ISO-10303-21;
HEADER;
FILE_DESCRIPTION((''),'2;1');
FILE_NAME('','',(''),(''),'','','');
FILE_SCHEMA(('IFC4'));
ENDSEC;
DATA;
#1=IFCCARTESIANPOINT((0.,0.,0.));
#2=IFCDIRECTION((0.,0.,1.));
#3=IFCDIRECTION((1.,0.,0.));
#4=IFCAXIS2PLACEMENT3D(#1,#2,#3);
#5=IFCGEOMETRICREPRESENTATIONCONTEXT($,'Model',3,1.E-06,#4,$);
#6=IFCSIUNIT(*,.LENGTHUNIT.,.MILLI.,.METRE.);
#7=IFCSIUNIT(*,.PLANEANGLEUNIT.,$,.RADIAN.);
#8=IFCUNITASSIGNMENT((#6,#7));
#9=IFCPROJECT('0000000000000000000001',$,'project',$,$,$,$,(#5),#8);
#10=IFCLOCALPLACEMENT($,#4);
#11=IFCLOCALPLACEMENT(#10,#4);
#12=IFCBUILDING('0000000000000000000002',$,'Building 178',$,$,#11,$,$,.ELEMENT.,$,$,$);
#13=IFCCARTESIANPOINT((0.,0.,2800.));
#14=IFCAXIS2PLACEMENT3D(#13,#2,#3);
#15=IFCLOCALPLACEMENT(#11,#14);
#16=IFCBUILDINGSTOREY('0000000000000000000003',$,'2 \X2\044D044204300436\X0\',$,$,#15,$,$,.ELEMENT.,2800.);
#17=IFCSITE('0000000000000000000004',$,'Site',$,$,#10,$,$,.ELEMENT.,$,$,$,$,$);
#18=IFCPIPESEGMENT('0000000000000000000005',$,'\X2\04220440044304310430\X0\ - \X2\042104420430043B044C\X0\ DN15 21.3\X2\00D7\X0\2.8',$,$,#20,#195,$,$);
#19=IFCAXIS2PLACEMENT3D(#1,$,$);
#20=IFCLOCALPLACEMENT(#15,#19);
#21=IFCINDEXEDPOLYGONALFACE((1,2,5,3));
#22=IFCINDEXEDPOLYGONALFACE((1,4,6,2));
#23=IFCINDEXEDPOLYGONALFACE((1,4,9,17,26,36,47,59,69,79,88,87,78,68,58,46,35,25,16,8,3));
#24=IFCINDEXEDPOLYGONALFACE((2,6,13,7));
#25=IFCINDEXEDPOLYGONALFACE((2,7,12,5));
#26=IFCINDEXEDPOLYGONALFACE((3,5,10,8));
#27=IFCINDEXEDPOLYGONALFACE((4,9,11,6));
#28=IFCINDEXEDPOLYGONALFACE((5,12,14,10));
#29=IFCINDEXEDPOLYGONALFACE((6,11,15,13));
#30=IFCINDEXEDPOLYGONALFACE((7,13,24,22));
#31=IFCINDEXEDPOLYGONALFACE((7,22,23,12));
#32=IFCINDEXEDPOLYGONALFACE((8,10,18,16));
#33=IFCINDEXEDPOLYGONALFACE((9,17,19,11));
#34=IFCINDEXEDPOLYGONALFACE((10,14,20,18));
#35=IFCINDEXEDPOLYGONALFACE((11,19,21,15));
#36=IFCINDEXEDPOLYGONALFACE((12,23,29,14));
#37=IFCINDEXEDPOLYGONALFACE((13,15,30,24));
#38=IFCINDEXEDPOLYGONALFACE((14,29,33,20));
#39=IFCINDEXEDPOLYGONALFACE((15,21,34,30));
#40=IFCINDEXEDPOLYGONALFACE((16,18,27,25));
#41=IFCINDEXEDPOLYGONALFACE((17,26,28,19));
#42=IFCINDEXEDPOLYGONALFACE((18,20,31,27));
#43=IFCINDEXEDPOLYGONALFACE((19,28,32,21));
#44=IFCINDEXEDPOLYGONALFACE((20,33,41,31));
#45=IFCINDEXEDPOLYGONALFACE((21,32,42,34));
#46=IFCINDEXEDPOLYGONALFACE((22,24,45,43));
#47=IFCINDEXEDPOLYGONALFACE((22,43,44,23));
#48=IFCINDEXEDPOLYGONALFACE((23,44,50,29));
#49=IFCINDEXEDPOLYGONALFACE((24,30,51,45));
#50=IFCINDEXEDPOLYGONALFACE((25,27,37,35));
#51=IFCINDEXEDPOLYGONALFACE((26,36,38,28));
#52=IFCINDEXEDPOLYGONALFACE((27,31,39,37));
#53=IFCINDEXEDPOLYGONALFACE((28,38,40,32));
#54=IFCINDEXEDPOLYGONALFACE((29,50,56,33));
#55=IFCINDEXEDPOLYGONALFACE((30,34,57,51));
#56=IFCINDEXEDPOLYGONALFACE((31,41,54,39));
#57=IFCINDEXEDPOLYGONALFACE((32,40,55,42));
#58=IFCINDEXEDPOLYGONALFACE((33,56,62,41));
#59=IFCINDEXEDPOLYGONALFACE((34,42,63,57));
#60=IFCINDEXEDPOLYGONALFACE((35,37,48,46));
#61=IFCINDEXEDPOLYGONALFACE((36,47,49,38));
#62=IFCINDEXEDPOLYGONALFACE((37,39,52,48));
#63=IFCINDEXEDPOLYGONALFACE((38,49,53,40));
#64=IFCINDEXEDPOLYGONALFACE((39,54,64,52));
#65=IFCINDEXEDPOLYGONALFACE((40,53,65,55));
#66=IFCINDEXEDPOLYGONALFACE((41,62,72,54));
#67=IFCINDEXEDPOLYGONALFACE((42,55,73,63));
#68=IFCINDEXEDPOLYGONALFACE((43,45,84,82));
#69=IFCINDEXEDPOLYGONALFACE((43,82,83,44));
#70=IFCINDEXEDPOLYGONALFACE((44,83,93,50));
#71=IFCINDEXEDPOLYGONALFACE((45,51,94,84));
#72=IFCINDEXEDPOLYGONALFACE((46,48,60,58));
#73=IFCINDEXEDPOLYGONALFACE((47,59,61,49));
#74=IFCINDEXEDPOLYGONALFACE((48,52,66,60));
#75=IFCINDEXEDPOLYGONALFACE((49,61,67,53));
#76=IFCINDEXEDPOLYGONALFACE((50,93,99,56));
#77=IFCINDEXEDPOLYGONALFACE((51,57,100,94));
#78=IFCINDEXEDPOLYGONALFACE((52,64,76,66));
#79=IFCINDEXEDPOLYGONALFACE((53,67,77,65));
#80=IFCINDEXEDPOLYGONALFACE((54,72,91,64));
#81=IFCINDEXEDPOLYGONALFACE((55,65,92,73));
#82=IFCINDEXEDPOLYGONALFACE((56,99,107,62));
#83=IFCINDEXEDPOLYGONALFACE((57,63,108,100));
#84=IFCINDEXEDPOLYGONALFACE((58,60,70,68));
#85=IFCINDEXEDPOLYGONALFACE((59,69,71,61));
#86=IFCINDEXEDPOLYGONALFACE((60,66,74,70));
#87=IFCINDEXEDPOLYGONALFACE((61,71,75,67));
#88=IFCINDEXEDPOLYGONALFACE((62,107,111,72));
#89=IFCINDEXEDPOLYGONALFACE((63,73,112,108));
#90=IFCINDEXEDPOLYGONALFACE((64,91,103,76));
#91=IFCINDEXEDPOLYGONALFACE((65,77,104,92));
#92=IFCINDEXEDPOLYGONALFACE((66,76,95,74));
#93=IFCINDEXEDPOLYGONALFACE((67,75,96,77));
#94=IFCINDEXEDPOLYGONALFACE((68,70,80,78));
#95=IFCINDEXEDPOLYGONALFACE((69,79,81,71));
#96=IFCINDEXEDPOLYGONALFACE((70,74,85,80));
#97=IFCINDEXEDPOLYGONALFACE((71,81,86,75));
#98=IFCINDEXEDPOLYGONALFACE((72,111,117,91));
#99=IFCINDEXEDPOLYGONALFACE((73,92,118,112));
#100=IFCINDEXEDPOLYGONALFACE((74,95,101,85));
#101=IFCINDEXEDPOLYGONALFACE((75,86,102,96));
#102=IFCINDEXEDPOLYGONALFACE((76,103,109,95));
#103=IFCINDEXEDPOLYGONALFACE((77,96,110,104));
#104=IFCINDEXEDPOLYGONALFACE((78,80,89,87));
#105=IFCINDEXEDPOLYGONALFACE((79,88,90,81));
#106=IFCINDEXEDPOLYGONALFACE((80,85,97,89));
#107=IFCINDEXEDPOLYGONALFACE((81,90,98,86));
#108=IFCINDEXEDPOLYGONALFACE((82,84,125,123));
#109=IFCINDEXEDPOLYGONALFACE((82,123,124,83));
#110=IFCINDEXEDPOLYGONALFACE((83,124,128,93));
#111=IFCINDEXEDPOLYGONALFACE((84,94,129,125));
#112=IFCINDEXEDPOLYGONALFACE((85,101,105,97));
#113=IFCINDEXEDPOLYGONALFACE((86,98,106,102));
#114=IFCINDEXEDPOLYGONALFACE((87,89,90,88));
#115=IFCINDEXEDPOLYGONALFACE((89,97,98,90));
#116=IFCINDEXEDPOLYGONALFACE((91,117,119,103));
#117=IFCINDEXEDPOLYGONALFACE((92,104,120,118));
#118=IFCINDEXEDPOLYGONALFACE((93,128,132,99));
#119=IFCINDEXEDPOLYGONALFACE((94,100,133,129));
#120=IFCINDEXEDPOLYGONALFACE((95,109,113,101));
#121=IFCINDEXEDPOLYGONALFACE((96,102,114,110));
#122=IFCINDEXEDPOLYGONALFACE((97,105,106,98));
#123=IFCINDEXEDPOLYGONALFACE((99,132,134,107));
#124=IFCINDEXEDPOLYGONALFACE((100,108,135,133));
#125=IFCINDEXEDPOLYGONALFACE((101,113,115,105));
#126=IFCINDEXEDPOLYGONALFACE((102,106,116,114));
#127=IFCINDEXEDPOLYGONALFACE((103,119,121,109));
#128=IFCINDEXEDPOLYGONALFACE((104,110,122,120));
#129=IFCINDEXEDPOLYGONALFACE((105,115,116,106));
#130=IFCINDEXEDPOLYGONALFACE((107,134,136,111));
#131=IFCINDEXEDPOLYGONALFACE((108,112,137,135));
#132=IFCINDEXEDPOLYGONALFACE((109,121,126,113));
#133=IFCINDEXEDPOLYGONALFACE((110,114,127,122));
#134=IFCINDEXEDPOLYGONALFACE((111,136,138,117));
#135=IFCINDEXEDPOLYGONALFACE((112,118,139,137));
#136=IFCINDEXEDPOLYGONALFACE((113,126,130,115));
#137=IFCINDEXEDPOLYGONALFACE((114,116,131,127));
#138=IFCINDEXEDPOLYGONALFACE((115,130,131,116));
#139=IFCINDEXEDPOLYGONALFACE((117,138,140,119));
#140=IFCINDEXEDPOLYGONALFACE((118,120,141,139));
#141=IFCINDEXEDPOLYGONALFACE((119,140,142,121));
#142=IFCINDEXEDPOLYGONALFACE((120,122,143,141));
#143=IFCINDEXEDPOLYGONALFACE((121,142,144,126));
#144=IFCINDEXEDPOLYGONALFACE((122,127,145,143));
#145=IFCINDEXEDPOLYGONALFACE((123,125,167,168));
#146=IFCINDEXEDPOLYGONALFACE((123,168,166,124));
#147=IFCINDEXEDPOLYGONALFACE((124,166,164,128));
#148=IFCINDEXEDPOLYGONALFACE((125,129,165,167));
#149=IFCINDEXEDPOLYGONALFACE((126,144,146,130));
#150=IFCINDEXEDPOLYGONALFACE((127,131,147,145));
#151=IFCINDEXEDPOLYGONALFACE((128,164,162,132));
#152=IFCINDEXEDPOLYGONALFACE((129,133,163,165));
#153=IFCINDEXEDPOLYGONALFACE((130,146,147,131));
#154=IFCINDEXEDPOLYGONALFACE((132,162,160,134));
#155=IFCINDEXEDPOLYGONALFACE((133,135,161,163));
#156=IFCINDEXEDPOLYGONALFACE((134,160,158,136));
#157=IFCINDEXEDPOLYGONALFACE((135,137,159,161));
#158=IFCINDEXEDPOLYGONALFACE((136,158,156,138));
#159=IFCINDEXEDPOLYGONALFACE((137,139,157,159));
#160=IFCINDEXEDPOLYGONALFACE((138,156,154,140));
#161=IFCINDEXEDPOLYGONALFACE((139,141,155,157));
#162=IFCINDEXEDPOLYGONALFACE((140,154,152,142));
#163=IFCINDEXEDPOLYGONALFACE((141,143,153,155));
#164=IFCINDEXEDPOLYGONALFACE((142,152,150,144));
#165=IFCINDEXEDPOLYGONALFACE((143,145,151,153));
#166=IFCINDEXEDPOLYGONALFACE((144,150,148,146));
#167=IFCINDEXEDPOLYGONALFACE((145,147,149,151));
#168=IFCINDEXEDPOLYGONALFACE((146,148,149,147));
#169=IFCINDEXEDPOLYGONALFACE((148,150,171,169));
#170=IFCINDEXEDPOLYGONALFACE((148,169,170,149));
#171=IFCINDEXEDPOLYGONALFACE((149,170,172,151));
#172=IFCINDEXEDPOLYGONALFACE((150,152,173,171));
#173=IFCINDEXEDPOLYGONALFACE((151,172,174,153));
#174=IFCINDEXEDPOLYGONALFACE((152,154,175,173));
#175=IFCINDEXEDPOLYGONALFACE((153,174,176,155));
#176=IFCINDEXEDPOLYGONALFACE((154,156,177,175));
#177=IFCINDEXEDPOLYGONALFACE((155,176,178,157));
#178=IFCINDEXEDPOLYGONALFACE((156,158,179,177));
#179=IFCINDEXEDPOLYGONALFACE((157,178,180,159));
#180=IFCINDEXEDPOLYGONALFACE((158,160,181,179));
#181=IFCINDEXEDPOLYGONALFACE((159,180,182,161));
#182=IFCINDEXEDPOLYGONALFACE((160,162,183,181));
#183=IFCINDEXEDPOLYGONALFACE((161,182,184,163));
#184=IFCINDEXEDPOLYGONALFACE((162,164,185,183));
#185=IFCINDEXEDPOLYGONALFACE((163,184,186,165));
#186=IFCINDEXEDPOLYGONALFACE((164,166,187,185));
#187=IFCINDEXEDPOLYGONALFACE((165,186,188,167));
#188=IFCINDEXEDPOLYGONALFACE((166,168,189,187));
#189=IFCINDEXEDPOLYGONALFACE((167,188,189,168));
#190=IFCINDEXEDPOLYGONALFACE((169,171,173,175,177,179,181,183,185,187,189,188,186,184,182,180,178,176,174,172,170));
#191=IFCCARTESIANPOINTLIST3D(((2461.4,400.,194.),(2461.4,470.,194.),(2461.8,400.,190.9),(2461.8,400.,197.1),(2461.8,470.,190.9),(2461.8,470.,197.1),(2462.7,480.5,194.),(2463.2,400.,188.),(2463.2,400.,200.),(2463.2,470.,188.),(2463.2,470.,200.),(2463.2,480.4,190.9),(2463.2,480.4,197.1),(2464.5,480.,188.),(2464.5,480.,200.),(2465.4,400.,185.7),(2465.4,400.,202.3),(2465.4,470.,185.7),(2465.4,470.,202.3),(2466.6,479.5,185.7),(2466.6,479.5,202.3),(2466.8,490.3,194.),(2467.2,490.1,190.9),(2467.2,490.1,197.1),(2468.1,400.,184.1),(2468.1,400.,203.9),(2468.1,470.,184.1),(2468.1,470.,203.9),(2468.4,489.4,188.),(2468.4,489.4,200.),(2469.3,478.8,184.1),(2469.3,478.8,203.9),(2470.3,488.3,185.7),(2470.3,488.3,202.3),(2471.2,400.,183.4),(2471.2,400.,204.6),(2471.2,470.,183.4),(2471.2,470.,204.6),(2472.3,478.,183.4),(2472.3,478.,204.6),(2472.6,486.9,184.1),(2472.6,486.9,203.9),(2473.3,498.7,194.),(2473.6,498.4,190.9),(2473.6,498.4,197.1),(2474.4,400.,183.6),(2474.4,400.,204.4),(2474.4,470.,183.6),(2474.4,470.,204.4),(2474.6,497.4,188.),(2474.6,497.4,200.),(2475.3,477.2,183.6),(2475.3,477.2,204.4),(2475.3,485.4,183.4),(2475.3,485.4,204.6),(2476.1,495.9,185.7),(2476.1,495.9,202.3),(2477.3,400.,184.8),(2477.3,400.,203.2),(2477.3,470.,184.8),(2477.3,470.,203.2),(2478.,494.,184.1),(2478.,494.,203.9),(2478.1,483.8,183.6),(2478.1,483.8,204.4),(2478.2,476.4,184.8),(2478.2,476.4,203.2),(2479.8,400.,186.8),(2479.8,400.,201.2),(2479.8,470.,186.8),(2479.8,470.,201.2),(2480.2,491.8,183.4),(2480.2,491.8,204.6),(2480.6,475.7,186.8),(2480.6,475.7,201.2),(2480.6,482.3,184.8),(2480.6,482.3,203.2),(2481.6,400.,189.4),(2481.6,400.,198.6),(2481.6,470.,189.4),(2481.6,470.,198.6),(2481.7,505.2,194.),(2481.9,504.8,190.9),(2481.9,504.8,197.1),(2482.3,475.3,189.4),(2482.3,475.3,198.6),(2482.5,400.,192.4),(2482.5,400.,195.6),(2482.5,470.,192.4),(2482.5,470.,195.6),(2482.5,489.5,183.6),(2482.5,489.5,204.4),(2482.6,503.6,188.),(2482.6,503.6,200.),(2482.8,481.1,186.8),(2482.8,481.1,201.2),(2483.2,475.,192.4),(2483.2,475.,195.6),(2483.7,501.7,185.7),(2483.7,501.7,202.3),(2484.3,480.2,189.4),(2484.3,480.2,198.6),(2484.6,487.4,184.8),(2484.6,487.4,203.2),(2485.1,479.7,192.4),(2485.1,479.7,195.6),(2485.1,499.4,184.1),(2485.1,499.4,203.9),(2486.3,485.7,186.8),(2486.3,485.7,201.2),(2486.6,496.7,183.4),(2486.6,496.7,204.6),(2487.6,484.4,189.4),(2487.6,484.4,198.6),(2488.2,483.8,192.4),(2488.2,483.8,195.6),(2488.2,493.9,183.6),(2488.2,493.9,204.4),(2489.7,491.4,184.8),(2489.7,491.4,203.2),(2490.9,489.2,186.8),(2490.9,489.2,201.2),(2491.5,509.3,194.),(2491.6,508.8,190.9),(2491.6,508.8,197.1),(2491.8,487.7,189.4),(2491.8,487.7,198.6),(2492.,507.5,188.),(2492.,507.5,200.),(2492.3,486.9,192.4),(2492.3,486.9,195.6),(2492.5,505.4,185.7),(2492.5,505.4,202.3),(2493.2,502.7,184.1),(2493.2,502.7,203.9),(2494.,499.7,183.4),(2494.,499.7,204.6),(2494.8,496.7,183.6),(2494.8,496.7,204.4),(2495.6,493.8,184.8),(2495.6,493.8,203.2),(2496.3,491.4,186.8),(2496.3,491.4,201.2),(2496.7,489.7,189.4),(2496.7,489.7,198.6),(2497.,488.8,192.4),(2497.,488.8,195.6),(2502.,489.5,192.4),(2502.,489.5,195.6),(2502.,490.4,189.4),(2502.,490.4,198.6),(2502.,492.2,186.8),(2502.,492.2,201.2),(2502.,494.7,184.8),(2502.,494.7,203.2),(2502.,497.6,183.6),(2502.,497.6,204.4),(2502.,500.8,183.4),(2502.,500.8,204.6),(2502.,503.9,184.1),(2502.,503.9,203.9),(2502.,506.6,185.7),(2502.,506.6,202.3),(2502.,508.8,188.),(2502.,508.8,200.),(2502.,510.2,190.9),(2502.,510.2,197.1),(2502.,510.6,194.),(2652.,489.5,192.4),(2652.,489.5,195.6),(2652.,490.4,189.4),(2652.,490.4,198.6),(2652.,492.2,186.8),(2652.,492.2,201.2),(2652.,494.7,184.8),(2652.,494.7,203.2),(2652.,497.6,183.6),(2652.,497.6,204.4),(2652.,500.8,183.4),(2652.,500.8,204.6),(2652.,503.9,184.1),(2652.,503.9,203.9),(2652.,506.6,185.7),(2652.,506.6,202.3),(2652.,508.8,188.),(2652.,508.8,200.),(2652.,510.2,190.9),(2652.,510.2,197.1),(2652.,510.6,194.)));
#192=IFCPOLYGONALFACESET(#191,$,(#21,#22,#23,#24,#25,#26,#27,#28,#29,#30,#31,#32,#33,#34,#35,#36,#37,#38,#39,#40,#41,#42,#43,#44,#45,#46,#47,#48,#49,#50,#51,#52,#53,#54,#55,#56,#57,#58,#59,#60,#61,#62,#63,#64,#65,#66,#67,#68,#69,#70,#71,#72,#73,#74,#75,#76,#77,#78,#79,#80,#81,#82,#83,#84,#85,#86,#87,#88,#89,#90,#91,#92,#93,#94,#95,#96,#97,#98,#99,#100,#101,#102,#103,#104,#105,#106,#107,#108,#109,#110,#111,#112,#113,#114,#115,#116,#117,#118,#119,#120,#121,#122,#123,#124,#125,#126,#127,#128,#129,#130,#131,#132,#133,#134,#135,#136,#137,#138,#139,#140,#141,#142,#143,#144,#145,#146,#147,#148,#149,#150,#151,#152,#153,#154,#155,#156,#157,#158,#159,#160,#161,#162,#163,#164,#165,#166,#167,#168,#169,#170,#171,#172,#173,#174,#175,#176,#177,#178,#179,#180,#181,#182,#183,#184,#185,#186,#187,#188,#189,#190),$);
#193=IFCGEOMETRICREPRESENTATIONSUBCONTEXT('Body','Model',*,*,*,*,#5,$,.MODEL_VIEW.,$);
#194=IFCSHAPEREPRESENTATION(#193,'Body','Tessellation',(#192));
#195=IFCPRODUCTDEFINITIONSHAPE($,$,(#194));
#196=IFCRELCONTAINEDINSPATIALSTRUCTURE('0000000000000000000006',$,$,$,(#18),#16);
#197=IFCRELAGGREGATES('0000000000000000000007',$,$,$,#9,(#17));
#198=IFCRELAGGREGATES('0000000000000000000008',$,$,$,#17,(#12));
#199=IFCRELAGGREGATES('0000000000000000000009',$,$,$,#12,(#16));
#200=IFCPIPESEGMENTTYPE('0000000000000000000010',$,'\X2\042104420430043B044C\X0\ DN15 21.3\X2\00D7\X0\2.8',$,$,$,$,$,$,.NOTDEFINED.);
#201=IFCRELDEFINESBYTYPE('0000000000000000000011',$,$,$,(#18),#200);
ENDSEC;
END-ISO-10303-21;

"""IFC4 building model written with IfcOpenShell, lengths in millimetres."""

from ifc_helpers import new_model, entity, si_unit, frame, origin_with_axes, place, context, subcontext, project, spatial, source, transform, mapped, type_object, element, save


model = new_model("IFC4")

# Units and contexts
model_context = context("Model", 3, precision=1e-06, world=origin_with_axes())
body_context = subcontext(model_context, "Body", "Model", "MODEL_VIEW")
ifc_project = project(units=[si_unit("LENGTHUNIT", "METRE", prefix="MILLI"), si_unit("PLANEANGLEUNIT", "RADIAN")], contexts=[model_context])

# Site, building, storey
site_placement = place(None, origin_with_axes())
site = spatial("IfcSite", under=ifc_project, at=site_placement, Name="Site", CompositionType="ELEMENT")
building_placement = place(site_placement, origin_with_axes())
building = spatial("IfcBuilding", under=site, at=building_placement, Name="Building 178", CompositionType="ELEMENT")
storey_placement = place(building_placement, frame((0.0, 0.0, 2800.0), z_axis=(0.0, 0.0, 1.0), x_axis=(1.0, 0.0, 0.0)))
storey = spatial("IfcBuildingStorey", under=building, at=storey_placement, Name="2 этаж", CompositionType="ELEMENT", Elevation=2800.0)

# Pipe segment
pipe_segment_type = type_object("IfcPipeSegmentType", Name="Сталь DN15 21.3×2.8", PredefinedType="NOTDEFINED")
shared_shape_1 = source(origin_with_axes(), body_context, "Body", "AdvancedSweptSolid", [
    entity("IfcSweptDiskSolid", entity("IfcIndexedPolyCurve", entity("IfcCartesianPointList3D", [[0.0, 0.0, 0.0], [0.0, 0.0, -70.0], [8.8, 0.0, -91.2], [30.0, 0.0, -100.0], [180.0, 0.0, -100.0]]), [entity("IfcLineIndex", [1, 2]), entity("IfcArcIndex", [2, 3, 4]), entity("IfcLineIndex", [4, 5])]), 10.7),
])
for number, where, z_axis, x_axis, name in (
    (1, (2472.0, 400.0, 194.0), (0.0, -1.0, 0.0), (1.0, 0.0, 0.0), "Труба - Сталь DN15 21.3×2.8"),
):
    element("IfcPipeSegment", number, at=place(storey_placement, frame(where, z_axis=z_axis, x_axis=x_axis)), inside=storey, type_object=pipe_segment_type, Name=name, context=body_context, shape_type="MappedRepresentation", body=[
        mapped(shared_shape_1, transform((0.0, 0.0, 0.0), x_axis=(1.0, 0.0, 0.0), y_axis=(0.0, 1.0, 0.0), z_axis=(0.0, 0.0, 1.0), scale=1.0)),
    ])

save(model, "model.ifc")
